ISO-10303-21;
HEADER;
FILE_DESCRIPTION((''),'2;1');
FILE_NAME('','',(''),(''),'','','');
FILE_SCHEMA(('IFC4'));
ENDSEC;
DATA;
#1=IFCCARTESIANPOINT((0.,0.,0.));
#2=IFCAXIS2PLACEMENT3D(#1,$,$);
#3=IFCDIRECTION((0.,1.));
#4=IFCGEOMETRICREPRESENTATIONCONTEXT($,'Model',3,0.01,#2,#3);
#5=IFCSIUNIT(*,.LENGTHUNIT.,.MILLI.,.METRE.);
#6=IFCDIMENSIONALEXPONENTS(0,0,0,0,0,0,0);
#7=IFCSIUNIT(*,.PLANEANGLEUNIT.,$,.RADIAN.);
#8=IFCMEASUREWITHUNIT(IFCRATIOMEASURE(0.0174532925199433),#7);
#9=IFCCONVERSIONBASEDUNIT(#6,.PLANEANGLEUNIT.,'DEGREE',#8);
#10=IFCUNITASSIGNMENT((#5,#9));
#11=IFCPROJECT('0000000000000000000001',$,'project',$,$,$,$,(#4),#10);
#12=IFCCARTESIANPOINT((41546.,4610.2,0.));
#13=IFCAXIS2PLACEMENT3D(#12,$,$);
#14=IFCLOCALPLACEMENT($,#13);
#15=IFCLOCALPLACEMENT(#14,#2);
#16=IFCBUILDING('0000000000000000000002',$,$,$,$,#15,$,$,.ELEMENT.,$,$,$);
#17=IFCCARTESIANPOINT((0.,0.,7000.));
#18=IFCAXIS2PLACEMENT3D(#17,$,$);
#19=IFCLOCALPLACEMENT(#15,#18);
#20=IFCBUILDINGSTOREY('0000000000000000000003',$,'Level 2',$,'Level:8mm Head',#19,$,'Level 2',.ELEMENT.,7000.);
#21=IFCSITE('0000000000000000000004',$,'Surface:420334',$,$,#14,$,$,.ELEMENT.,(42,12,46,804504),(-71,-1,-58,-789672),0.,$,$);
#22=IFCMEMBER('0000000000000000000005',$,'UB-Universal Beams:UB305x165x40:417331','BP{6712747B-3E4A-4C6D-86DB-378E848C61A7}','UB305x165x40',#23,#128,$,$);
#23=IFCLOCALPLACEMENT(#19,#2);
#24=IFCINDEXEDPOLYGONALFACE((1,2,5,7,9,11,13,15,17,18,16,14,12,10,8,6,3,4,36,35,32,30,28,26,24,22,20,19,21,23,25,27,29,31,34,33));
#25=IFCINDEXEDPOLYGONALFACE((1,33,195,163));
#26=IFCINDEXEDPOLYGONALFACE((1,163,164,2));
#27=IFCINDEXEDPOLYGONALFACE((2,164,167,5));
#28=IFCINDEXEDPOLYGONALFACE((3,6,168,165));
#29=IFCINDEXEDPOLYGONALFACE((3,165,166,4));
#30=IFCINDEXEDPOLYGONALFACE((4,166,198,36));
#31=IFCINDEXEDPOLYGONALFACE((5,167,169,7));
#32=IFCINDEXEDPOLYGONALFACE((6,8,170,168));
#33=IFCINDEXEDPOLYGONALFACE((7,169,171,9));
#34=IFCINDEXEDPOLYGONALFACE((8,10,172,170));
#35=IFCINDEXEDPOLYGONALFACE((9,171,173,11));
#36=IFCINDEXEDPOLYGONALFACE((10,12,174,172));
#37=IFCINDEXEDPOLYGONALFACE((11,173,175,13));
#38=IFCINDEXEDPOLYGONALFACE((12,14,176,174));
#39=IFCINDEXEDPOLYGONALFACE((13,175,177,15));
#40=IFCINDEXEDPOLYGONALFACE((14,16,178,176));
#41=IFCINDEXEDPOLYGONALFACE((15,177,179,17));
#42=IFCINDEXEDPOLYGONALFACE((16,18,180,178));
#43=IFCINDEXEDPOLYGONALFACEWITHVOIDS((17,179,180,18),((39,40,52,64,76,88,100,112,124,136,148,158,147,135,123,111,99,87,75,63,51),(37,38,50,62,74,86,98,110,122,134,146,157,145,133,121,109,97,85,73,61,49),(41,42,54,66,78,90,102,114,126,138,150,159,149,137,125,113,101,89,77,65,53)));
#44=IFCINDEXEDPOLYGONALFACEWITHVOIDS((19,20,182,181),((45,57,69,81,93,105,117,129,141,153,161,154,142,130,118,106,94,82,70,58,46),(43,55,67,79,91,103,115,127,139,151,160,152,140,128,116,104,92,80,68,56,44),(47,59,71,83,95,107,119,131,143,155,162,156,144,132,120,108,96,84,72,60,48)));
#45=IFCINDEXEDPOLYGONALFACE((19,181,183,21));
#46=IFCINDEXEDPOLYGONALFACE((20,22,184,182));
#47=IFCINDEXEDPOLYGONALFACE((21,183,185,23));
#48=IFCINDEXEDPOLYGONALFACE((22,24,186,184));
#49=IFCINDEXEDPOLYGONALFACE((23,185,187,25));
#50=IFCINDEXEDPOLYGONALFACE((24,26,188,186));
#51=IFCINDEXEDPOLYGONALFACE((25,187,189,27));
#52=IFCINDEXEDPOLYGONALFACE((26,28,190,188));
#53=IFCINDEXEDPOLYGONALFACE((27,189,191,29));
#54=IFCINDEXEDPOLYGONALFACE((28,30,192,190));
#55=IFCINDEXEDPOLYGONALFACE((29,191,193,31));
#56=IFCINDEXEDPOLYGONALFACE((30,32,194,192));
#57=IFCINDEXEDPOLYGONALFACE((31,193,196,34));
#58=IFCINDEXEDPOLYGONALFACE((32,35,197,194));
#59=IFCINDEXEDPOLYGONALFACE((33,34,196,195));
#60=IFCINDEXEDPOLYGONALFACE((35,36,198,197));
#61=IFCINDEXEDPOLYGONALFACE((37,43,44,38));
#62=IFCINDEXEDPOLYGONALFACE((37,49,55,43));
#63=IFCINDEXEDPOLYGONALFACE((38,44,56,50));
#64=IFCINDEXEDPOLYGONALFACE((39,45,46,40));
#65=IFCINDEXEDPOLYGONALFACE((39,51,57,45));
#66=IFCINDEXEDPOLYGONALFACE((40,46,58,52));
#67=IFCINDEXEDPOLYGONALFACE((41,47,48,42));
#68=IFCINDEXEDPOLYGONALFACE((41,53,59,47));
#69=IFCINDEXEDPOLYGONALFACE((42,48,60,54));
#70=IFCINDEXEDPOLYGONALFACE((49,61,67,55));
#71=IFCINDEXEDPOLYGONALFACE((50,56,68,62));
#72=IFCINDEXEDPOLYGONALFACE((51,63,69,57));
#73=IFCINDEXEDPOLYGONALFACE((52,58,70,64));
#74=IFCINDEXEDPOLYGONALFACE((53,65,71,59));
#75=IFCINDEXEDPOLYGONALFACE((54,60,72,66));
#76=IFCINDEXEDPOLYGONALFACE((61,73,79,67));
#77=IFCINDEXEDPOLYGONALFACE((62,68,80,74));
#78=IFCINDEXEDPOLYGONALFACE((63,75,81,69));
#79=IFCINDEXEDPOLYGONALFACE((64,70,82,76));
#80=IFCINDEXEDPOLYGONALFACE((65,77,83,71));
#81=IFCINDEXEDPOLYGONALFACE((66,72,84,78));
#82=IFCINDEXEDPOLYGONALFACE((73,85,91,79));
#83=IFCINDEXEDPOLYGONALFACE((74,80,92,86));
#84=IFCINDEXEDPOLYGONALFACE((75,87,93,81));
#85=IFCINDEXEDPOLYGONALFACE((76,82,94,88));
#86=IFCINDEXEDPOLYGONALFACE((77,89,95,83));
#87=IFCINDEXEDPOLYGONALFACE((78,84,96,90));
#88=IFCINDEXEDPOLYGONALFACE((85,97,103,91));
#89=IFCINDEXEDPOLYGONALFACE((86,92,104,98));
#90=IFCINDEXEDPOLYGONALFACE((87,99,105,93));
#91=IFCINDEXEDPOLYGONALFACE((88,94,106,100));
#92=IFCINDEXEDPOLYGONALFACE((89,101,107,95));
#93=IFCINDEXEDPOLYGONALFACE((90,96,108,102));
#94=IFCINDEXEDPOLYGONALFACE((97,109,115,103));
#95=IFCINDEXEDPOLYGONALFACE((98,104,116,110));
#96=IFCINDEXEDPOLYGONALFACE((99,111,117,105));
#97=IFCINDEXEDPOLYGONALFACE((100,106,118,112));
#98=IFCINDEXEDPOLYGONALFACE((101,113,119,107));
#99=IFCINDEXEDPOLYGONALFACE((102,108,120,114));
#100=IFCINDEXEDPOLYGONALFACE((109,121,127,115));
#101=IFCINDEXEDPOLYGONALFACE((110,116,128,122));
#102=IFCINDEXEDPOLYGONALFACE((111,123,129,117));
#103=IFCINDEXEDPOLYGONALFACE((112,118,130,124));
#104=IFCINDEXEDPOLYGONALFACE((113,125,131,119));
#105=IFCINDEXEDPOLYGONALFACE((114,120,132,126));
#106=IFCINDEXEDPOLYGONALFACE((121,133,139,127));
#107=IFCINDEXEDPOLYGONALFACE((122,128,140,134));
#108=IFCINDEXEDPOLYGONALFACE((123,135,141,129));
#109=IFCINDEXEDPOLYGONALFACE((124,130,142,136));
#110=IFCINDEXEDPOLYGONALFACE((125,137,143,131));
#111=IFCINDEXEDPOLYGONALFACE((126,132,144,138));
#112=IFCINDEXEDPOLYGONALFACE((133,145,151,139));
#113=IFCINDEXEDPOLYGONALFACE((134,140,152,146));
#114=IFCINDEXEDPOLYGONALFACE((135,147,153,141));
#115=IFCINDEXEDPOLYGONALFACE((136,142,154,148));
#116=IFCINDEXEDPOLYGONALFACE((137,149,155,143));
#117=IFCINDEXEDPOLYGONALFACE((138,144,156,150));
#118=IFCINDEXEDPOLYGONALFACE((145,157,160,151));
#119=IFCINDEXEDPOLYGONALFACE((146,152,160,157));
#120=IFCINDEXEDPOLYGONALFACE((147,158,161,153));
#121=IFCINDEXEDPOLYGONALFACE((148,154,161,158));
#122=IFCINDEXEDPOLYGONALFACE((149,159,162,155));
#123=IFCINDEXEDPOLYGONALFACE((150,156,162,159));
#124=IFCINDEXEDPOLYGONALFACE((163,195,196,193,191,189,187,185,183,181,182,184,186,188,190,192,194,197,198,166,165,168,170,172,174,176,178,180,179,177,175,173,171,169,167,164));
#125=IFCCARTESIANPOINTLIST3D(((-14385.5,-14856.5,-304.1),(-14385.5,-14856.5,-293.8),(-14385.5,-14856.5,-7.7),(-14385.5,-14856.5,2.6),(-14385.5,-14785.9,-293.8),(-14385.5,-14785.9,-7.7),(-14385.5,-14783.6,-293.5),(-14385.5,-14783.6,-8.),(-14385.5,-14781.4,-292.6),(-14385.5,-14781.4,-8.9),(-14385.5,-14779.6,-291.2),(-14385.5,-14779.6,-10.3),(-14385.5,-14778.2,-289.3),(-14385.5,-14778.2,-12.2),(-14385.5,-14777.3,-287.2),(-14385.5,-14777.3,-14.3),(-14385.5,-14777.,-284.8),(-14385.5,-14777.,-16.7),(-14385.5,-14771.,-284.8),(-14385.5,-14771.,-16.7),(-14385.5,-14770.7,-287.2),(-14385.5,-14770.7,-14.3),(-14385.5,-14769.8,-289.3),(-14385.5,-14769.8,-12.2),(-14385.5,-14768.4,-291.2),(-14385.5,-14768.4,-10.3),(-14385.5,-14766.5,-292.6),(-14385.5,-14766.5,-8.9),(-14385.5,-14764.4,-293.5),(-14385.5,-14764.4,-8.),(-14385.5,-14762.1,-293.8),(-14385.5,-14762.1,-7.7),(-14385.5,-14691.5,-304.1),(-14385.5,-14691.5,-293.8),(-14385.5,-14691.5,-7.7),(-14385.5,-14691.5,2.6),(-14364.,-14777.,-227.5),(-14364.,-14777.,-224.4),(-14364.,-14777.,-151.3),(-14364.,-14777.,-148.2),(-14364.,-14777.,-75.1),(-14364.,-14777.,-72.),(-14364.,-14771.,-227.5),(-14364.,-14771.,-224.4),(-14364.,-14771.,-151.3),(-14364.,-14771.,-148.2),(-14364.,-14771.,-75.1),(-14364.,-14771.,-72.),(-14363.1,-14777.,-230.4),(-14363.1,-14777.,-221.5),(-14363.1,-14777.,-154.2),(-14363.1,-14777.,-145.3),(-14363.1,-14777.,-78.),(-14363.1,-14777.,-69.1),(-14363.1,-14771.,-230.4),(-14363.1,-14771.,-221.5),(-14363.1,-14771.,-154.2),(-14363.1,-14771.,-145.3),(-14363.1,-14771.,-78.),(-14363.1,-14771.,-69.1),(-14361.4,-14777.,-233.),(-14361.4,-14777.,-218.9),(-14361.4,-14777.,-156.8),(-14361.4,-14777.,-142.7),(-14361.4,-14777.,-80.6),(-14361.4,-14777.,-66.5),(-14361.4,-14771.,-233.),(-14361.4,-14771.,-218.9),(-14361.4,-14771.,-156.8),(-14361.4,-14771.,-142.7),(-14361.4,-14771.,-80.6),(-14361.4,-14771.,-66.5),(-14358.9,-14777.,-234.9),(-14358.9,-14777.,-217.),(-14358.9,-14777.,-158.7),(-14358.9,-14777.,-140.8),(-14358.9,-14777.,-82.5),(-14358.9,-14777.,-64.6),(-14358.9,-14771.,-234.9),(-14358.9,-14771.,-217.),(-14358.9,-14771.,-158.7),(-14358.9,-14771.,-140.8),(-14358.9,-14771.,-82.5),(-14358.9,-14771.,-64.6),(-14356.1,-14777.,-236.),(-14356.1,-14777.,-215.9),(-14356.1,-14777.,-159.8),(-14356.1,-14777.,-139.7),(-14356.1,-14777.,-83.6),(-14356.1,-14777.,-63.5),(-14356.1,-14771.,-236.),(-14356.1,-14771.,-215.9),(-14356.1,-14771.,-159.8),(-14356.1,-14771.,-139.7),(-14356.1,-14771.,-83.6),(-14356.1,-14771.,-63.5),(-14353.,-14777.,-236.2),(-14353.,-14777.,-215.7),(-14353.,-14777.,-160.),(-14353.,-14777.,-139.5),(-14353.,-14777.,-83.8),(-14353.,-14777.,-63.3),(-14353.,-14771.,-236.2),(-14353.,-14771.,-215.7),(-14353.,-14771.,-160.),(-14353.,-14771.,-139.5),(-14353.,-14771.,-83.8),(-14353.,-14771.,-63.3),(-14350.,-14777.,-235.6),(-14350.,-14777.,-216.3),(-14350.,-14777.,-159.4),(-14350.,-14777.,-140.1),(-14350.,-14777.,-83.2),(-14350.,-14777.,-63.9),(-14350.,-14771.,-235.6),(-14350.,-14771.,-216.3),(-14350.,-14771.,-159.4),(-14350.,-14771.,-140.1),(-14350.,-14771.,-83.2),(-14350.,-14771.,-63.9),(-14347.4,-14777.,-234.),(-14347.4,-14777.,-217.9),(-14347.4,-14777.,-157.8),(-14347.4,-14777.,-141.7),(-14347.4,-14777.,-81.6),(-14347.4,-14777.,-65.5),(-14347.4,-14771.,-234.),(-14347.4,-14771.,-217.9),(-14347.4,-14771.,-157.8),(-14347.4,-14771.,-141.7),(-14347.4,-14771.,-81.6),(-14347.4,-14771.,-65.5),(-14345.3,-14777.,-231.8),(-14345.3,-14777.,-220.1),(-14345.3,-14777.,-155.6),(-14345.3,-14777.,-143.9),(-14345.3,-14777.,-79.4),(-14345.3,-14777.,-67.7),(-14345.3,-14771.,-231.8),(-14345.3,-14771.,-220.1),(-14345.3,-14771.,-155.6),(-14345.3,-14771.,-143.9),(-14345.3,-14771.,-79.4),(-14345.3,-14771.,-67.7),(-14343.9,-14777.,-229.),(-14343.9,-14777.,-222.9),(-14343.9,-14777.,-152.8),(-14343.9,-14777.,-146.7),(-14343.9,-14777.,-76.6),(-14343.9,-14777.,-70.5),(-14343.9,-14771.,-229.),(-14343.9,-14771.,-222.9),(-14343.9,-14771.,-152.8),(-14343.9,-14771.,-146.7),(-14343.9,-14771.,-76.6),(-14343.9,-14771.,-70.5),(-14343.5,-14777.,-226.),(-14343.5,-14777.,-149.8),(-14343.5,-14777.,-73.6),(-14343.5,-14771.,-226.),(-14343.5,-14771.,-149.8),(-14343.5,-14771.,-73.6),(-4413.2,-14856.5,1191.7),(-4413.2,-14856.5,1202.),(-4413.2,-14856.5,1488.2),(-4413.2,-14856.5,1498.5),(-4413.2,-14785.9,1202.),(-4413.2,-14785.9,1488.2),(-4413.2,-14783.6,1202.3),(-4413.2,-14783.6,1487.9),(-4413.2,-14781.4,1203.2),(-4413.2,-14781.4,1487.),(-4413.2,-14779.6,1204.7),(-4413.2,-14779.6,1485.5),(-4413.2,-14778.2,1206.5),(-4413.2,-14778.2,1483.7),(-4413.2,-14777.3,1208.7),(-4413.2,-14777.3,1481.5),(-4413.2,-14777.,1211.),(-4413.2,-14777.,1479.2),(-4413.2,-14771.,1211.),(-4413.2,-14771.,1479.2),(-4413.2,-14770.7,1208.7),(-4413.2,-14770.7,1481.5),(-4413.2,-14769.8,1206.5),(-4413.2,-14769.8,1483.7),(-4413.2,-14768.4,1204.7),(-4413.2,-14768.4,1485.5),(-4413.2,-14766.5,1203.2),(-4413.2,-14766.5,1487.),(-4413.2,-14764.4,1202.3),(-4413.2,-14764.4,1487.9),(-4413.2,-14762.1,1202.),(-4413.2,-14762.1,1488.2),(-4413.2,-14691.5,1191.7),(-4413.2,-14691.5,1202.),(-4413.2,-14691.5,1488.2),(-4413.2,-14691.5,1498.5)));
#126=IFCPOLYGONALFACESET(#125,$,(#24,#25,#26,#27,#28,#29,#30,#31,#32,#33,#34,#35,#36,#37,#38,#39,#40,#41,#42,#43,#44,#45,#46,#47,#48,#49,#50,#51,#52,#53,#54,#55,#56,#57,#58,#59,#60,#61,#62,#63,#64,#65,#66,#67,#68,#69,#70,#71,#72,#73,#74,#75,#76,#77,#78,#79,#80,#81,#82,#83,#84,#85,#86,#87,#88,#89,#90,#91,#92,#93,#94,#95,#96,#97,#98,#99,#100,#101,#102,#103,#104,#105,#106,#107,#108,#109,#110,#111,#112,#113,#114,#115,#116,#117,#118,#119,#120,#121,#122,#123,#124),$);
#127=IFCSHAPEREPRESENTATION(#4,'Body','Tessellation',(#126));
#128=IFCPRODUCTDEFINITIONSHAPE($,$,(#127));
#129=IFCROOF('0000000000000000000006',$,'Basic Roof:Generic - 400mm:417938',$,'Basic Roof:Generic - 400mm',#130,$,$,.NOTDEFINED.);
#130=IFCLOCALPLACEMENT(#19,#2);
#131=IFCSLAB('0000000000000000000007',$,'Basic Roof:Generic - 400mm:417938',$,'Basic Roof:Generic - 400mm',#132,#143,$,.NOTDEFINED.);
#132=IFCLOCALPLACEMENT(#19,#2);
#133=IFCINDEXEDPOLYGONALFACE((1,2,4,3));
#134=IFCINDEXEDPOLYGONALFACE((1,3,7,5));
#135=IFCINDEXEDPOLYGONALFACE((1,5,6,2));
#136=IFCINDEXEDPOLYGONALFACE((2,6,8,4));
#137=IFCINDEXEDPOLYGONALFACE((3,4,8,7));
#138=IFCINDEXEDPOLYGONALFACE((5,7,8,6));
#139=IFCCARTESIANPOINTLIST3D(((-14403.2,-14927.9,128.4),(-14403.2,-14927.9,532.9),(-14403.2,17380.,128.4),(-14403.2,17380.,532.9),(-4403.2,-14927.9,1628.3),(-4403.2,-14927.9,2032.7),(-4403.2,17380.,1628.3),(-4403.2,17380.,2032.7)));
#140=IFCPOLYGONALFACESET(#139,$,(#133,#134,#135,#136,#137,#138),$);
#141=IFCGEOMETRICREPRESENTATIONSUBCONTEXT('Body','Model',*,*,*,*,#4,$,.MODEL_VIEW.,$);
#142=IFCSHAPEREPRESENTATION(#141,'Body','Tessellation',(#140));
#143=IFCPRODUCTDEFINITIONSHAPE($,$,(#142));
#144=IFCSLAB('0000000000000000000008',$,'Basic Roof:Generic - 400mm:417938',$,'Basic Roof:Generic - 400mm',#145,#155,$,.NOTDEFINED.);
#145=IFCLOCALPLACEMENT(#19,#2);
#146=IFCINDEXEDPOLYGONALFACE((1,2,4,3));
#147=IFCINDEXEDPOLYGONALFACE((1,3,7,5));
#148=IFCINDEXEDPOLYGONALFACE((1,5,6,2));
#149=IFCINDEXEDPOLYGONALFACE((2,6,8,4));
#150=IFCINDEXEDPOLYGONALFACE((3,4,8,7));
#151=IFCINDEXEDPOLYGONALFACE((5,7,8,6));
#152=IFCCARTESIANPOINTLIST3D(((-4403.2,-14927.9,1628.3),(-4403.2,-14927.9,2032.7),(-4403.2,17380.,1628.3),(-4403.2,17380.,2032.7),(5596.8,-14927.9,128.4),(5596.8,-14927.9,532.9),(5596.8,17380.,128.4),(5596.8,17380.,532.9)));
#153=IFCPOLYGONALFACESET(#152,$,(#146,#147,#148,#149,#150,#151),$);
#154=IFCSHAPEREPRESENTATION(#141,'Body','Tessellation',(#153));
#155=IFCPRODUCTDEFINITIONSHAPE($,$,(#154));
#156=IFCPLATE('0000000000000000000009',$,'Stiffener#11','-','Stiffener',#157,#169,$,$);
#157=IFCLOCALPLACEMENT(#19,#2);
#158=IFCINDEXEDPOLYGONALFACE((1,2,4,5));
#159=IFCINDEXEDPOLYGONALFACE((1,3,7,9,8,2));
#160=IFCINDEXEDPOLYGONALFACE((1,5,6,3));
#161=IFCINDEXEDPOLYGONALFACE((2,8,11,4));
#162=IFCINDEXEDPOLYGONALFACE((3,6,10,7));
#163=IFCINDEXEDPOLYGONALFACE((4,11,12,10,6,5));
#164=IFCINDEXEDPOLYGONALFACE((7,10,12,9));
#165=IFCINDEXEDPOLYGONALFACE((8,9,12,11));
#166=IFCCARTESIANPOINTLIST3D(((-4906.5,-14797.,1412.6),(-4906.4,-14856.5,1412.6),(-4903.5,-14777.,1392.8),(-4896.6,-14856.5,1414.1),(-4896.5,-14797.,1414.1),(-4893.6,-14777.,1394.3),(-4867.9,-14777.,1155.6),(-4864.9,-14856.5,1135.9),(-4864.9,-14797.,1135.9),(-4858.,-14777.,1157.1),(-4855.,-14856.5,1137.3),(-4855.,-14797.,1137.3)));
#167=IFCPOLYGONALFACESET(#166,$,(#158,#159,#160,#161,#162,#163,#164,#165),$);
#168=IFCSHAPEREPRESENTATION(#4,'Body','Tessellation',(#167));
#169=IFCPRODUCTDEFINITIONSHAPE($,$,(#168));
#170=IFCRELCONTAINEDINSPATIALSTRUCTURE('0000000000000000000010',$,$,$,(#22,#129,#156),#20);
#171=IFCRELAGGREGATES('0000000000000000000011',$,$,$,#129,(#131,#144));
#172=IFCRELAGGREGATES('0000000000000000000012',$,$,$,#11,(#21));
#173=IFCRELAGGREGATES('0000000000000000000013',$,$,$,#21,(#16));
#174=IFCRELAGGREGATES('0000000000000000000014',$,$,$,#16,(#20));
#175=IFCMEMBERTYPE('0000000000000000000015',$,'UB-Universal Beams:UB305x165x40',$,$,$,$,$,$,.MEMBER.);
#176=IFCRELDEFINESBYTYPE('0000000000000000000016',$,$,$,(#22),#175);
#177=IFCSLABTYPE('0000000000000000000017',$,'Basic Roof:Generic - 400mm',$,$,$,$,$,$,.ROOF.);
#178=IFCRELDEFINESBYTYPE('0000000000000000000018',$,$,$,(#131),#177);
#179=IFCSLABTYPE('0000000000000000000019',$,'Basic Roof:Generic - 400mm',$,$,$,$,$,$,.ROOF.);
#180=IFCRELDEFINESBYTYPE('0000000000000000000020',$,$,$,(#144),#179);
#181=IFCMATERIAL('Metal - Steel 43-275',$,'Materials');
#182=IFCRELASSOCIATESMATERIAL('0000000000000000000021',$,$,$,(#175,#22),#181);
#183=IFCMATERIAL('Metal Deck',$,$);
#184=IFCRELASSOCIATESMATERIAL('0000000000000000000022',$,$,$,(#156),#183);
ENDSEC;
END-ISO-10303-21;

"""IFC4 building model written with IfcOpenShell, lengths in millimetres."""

from ifc_helpers import new_model, entity, si_unit, converted_unit, direction, frame, frame_2d, origin, origin_with_axes, origin_2d, origin_2d_with_axis, place, context, subcontext, project, spatial, polyline, rectangle, circle, i_section, outline, extrude, clip, halfspace, material, type_object, element, aggregate, save


model = new_model("IFC4")

# Units and contexts
model_context = context("Model", 3, precision=0.01, world=origin(), true_north=direction((0.0, 1.0)))
body_context = subcontext(model_context, "Body", "Model", "MODEL_VIEW")
ifc_project = project(units=[si_unit("LENGTHUNIT", "METRE", prefix="MILLI"), converted_unit("PLANEANGLEUNIT", "DEGREE", entity("IfcRatioMeasure", 0.0174532925199433), si_unit("PLANEANGLEUNIT", "RADIAN"), dimensions=[0, 0, 0, 0, 0, 0, 0])], contexts=[model_context])

# Site, building, storey
site_placement = place(None, frame((41546.0, 4610.2, 0.0)))
site = spatial("IfcSite", under=ifc_project, at=site_placement, Name="Surface:420334", CompositionType="ELEMENT", RefLatitude=(42, 12, 46, 804504), RefLongitude=(-71, -1, -58, -789672), RefElevation=0.0)
building_placement = place(site_placement, origin())
building = spatial("IfcBuilding", under=site, at=building_placement, CompositionType="ELEMENT")
storey_placement = place(building_placement, frame((0.0, 0.0, 7000.0)))
storey = spatial("IfcBuildingStorey", under=building, at=storey_placement, Name="Level 2", ObjectType="Level:8mm Head", LongName="Level 2", CompositionType="ELEMENT", Elevation=7000.0)

# Shared definitions
ifc_material_1 = material(Name="Metal - Steel 43-275", Category="Materials")

# Member, openings
member_type_1 = type_object("IfcMemberType", Name="UB-Universal Beams:UB305x165x40", PredefinedType="MEMBER", material=ifc_material_1)
member_1_placement = place(storey_placement, frame((-14856.8, -14774.0, -221.4), z_axis=(-0.988936, 0.0, -0.14834), x_axis=(0.0, -1.0, 0.0)))
member_1 = element("IfcMember", 1, at=member_1_placement, inside=storey, type_object=member_type_1, material=ifc_material_1, Name="UB-Universal Beams:UB305x165x40:417331", Description="BP{6712747B-3E4A-4C6D-86DB-378E848C61A7}", ObjectType="UB305x165x40", context=model_context, shape_type="Clipping", body=[
    clip(clip(extrude(i_section(OverallWidth=165.0, OverallDepth=303.4, WebThickness=6.0, FlangeThickness=10.2, FilletRadius=8.9, at=origin_2d()), origin(), (0.0, 0.0, -1.0), 11074.7), halfspace(frame((-14774.0, -8252.8, -9322.5), z_axis=(0.0, 0.14834, 0.988936), x_axis=(1.0, 0.0, 0.0)), True)), halfspace(frame((-14774.0, -6773.5, 539.5), z_axis=(0.0, -0.14834, -0.988936), x_axis=(-1.0, 0.0, 0.0)), True)),
])
opening_1_placement = place(member_1_placement, frame((3.5, -3.7, -508.0), z_axis=(-1.0, 0.0, 0.0), x_axis=(0.0, -0.14834, -0.988936)))
element("IfcOpeningElement", 2, at=opening_1_placement, cuts=member_1, ObjectType="Opening", context=model_context, shape_type="SweptSolid", body=[
    extrude(circle(Radius=10.3, at=origin_2d_with_axis()), origin(), (0.0, 0.0, 1.0), 7.0),
])
opening_2_placement = place(member_1_placement, frame((3.5, -3.7, -508.0), z_axis=(-1.0, 0.0, 0.0), x_axis=(0.0, -0.14834, -0.988936)))
element("IfcOpeningElement", 3, at=opening_2_placement, cuts=member_1, ObjectType="Opening", context=model_context, shape_type="SweptSolid", body=[
    extrude(circle(Radius=10.3, at=frame_2d((0.0, 76.2), x_axis=(1.0, 0.0))), origin(), (0.0, 0.0, 1.0), 7.0),
])
opening_3_placement = place(member_1_placement, frame((3.5, -3.7, -508.0), z_axis=(-1.0, 0.0, 0.0), x_axis=(0.0, -0.14834, -0.988936)))
element("IfcOpeningElement", 4, at=opening_3_placement, cuts=member_1, ObjectType="Opening", context=model_context, shape_type="SweptSolid", body=[
    extrude(circle(Radius=10.3, at=frame_2d((0.0, -76.2), x_axis=(1.0, 0.0))), origin(), (0.0, 0.0, 1.0), 7.0),
])

# Roof, slabs
roof_placement = place(storey_placement, frame((-14403.2, -14927.9, 128.4)))
roof = element("IfcRoof", 5, at=roof_placement, inside=storey, Name="Basic Roof:Generic - 400mm:417938", ObjectType="Basic Roof:Generic - 400mm", PredefinedType="NOTDEFINED")
slab_type_1 = type_object("IfcSlabType", Name="Basic Roof:Generic - 400mm", PredefinedType="ROOF")
slab_1_placement = place(roof_placement, origin())
slab_1 = element("IfcSlab", 6, at=slab_1_placement, type_object=slab_type_1, Name="Basic Roof:Generic - 400mm:417938", ObjectType="Basic Roof:Generic - 400mm", PredefinedType="NOTDEFINED", context=body_context, shape_type="SweptSolid", body=[
    extrude(rectangle(XDim=10111.9, YDim=32307.9, at=frame_2d((0.0, 0.0), x_axis=(-1.0, 0.0))), frame((5000.0, 16154.0, 749.9), z_axis=(-0.148327, 0.0, 0.988938), x_axis=(0.988938, 0.0, 0.148327)), (0.148327, 0.0, 0.988938), 404.5),
])
slab_type_2 = type_object("IfcSlabType", Name="Basic Roof:Generic - 400mm", PredefinedType="ROOF")
slab_2_placement = place(roof_placement, origin())
slab_2 = element("IfcSlab", 7, at=slab_2_placement, type_object=slab_type_2, Name="Basic Roof:Generic - 400mm:417938", ObjectType="Basic Roof:Generic - 400mm", PredefinedType="NOTDEFINED", context=body_context, shape_type="SweptSolid", body=[
    extrude(rectangle(XDim=32307.9, YDim=10111.9, at=frame_2d((0.0, 0.0), x_axis=(0.0, -1.0))), frame((15000.0, 16154.0, 749.9), z_axis=(0.148327, 0.0, 0.988938), x_axis=(0.988938, 0.0, -0.148327)), (-0.148327, 0.0, 0.988938), 404.5),
])
aggregate(roof, [slab_1, slab_2])

# Plate, openings
ifc_material_2 = material(Name="Metal Deck")
plate_placement = place(storey_placement, frame((-4855.0, -14777.0, 1137.3), z_axis=(-0.988936, 0.0, -0.14834), x_axis=(0.0, -1.0, 0.0)))
plate = element("IfcPlate", 8, at=plate_placement, inside=storey, material=ifc_material_2, Name="Stiffener#11", Description="-", ObjectType="Stiffener", context=model_context, shape_type="SweptSolid", body=[
    extrude(outline(polyline([(0.0, 0.0), (79.5, 0.0), (79.5, 279.8), (0.0, 279.8), (0.0, 0.0)])), origin_with_axes(), (0.0, 0.0, 1.0), 10.0),
])
opening_4_placement = place(plate_placement, frame((0.0, 0.0, 0.0), z_axis=(0.0, 0.0, 1.0), x_axis=(1.0, 0.0, 0.0)))
element("IfcOpeningElement", 9, at=opening_4_placement, cuts=plate, ObjectType="Opening", context=model_context, shape_type="SweptSolid", body=[
    extrude(outline(polyline([(0.0, 279.8), (0.0, 259.8), (20.0, 279.8), (0.0, 279.8)])), origin(), (0.0, 0.0, 1.0), 10.0),
])
opening_5_placement = place(plate_placement, frame((0.0, 0.0, 0.0), z_axis=(0.0, 0.0, 1.0), x_axis=(1.0, 0.0, 0.0)))
element("IfcOpeningElement", 10, at=opening_5_placement, cuts=plate, ObjectType="Opening", context=model_context, shape_type="SweptSolid", body=[
    extrude(outline(polyline([(0.0, 0.0), (20.0, 0.0), (0.0, 20.0), (0.0, 0.0)])), origin(), (0.0, 0.0, 1.0), 10.0),
])

save(model, "model.ifc")
